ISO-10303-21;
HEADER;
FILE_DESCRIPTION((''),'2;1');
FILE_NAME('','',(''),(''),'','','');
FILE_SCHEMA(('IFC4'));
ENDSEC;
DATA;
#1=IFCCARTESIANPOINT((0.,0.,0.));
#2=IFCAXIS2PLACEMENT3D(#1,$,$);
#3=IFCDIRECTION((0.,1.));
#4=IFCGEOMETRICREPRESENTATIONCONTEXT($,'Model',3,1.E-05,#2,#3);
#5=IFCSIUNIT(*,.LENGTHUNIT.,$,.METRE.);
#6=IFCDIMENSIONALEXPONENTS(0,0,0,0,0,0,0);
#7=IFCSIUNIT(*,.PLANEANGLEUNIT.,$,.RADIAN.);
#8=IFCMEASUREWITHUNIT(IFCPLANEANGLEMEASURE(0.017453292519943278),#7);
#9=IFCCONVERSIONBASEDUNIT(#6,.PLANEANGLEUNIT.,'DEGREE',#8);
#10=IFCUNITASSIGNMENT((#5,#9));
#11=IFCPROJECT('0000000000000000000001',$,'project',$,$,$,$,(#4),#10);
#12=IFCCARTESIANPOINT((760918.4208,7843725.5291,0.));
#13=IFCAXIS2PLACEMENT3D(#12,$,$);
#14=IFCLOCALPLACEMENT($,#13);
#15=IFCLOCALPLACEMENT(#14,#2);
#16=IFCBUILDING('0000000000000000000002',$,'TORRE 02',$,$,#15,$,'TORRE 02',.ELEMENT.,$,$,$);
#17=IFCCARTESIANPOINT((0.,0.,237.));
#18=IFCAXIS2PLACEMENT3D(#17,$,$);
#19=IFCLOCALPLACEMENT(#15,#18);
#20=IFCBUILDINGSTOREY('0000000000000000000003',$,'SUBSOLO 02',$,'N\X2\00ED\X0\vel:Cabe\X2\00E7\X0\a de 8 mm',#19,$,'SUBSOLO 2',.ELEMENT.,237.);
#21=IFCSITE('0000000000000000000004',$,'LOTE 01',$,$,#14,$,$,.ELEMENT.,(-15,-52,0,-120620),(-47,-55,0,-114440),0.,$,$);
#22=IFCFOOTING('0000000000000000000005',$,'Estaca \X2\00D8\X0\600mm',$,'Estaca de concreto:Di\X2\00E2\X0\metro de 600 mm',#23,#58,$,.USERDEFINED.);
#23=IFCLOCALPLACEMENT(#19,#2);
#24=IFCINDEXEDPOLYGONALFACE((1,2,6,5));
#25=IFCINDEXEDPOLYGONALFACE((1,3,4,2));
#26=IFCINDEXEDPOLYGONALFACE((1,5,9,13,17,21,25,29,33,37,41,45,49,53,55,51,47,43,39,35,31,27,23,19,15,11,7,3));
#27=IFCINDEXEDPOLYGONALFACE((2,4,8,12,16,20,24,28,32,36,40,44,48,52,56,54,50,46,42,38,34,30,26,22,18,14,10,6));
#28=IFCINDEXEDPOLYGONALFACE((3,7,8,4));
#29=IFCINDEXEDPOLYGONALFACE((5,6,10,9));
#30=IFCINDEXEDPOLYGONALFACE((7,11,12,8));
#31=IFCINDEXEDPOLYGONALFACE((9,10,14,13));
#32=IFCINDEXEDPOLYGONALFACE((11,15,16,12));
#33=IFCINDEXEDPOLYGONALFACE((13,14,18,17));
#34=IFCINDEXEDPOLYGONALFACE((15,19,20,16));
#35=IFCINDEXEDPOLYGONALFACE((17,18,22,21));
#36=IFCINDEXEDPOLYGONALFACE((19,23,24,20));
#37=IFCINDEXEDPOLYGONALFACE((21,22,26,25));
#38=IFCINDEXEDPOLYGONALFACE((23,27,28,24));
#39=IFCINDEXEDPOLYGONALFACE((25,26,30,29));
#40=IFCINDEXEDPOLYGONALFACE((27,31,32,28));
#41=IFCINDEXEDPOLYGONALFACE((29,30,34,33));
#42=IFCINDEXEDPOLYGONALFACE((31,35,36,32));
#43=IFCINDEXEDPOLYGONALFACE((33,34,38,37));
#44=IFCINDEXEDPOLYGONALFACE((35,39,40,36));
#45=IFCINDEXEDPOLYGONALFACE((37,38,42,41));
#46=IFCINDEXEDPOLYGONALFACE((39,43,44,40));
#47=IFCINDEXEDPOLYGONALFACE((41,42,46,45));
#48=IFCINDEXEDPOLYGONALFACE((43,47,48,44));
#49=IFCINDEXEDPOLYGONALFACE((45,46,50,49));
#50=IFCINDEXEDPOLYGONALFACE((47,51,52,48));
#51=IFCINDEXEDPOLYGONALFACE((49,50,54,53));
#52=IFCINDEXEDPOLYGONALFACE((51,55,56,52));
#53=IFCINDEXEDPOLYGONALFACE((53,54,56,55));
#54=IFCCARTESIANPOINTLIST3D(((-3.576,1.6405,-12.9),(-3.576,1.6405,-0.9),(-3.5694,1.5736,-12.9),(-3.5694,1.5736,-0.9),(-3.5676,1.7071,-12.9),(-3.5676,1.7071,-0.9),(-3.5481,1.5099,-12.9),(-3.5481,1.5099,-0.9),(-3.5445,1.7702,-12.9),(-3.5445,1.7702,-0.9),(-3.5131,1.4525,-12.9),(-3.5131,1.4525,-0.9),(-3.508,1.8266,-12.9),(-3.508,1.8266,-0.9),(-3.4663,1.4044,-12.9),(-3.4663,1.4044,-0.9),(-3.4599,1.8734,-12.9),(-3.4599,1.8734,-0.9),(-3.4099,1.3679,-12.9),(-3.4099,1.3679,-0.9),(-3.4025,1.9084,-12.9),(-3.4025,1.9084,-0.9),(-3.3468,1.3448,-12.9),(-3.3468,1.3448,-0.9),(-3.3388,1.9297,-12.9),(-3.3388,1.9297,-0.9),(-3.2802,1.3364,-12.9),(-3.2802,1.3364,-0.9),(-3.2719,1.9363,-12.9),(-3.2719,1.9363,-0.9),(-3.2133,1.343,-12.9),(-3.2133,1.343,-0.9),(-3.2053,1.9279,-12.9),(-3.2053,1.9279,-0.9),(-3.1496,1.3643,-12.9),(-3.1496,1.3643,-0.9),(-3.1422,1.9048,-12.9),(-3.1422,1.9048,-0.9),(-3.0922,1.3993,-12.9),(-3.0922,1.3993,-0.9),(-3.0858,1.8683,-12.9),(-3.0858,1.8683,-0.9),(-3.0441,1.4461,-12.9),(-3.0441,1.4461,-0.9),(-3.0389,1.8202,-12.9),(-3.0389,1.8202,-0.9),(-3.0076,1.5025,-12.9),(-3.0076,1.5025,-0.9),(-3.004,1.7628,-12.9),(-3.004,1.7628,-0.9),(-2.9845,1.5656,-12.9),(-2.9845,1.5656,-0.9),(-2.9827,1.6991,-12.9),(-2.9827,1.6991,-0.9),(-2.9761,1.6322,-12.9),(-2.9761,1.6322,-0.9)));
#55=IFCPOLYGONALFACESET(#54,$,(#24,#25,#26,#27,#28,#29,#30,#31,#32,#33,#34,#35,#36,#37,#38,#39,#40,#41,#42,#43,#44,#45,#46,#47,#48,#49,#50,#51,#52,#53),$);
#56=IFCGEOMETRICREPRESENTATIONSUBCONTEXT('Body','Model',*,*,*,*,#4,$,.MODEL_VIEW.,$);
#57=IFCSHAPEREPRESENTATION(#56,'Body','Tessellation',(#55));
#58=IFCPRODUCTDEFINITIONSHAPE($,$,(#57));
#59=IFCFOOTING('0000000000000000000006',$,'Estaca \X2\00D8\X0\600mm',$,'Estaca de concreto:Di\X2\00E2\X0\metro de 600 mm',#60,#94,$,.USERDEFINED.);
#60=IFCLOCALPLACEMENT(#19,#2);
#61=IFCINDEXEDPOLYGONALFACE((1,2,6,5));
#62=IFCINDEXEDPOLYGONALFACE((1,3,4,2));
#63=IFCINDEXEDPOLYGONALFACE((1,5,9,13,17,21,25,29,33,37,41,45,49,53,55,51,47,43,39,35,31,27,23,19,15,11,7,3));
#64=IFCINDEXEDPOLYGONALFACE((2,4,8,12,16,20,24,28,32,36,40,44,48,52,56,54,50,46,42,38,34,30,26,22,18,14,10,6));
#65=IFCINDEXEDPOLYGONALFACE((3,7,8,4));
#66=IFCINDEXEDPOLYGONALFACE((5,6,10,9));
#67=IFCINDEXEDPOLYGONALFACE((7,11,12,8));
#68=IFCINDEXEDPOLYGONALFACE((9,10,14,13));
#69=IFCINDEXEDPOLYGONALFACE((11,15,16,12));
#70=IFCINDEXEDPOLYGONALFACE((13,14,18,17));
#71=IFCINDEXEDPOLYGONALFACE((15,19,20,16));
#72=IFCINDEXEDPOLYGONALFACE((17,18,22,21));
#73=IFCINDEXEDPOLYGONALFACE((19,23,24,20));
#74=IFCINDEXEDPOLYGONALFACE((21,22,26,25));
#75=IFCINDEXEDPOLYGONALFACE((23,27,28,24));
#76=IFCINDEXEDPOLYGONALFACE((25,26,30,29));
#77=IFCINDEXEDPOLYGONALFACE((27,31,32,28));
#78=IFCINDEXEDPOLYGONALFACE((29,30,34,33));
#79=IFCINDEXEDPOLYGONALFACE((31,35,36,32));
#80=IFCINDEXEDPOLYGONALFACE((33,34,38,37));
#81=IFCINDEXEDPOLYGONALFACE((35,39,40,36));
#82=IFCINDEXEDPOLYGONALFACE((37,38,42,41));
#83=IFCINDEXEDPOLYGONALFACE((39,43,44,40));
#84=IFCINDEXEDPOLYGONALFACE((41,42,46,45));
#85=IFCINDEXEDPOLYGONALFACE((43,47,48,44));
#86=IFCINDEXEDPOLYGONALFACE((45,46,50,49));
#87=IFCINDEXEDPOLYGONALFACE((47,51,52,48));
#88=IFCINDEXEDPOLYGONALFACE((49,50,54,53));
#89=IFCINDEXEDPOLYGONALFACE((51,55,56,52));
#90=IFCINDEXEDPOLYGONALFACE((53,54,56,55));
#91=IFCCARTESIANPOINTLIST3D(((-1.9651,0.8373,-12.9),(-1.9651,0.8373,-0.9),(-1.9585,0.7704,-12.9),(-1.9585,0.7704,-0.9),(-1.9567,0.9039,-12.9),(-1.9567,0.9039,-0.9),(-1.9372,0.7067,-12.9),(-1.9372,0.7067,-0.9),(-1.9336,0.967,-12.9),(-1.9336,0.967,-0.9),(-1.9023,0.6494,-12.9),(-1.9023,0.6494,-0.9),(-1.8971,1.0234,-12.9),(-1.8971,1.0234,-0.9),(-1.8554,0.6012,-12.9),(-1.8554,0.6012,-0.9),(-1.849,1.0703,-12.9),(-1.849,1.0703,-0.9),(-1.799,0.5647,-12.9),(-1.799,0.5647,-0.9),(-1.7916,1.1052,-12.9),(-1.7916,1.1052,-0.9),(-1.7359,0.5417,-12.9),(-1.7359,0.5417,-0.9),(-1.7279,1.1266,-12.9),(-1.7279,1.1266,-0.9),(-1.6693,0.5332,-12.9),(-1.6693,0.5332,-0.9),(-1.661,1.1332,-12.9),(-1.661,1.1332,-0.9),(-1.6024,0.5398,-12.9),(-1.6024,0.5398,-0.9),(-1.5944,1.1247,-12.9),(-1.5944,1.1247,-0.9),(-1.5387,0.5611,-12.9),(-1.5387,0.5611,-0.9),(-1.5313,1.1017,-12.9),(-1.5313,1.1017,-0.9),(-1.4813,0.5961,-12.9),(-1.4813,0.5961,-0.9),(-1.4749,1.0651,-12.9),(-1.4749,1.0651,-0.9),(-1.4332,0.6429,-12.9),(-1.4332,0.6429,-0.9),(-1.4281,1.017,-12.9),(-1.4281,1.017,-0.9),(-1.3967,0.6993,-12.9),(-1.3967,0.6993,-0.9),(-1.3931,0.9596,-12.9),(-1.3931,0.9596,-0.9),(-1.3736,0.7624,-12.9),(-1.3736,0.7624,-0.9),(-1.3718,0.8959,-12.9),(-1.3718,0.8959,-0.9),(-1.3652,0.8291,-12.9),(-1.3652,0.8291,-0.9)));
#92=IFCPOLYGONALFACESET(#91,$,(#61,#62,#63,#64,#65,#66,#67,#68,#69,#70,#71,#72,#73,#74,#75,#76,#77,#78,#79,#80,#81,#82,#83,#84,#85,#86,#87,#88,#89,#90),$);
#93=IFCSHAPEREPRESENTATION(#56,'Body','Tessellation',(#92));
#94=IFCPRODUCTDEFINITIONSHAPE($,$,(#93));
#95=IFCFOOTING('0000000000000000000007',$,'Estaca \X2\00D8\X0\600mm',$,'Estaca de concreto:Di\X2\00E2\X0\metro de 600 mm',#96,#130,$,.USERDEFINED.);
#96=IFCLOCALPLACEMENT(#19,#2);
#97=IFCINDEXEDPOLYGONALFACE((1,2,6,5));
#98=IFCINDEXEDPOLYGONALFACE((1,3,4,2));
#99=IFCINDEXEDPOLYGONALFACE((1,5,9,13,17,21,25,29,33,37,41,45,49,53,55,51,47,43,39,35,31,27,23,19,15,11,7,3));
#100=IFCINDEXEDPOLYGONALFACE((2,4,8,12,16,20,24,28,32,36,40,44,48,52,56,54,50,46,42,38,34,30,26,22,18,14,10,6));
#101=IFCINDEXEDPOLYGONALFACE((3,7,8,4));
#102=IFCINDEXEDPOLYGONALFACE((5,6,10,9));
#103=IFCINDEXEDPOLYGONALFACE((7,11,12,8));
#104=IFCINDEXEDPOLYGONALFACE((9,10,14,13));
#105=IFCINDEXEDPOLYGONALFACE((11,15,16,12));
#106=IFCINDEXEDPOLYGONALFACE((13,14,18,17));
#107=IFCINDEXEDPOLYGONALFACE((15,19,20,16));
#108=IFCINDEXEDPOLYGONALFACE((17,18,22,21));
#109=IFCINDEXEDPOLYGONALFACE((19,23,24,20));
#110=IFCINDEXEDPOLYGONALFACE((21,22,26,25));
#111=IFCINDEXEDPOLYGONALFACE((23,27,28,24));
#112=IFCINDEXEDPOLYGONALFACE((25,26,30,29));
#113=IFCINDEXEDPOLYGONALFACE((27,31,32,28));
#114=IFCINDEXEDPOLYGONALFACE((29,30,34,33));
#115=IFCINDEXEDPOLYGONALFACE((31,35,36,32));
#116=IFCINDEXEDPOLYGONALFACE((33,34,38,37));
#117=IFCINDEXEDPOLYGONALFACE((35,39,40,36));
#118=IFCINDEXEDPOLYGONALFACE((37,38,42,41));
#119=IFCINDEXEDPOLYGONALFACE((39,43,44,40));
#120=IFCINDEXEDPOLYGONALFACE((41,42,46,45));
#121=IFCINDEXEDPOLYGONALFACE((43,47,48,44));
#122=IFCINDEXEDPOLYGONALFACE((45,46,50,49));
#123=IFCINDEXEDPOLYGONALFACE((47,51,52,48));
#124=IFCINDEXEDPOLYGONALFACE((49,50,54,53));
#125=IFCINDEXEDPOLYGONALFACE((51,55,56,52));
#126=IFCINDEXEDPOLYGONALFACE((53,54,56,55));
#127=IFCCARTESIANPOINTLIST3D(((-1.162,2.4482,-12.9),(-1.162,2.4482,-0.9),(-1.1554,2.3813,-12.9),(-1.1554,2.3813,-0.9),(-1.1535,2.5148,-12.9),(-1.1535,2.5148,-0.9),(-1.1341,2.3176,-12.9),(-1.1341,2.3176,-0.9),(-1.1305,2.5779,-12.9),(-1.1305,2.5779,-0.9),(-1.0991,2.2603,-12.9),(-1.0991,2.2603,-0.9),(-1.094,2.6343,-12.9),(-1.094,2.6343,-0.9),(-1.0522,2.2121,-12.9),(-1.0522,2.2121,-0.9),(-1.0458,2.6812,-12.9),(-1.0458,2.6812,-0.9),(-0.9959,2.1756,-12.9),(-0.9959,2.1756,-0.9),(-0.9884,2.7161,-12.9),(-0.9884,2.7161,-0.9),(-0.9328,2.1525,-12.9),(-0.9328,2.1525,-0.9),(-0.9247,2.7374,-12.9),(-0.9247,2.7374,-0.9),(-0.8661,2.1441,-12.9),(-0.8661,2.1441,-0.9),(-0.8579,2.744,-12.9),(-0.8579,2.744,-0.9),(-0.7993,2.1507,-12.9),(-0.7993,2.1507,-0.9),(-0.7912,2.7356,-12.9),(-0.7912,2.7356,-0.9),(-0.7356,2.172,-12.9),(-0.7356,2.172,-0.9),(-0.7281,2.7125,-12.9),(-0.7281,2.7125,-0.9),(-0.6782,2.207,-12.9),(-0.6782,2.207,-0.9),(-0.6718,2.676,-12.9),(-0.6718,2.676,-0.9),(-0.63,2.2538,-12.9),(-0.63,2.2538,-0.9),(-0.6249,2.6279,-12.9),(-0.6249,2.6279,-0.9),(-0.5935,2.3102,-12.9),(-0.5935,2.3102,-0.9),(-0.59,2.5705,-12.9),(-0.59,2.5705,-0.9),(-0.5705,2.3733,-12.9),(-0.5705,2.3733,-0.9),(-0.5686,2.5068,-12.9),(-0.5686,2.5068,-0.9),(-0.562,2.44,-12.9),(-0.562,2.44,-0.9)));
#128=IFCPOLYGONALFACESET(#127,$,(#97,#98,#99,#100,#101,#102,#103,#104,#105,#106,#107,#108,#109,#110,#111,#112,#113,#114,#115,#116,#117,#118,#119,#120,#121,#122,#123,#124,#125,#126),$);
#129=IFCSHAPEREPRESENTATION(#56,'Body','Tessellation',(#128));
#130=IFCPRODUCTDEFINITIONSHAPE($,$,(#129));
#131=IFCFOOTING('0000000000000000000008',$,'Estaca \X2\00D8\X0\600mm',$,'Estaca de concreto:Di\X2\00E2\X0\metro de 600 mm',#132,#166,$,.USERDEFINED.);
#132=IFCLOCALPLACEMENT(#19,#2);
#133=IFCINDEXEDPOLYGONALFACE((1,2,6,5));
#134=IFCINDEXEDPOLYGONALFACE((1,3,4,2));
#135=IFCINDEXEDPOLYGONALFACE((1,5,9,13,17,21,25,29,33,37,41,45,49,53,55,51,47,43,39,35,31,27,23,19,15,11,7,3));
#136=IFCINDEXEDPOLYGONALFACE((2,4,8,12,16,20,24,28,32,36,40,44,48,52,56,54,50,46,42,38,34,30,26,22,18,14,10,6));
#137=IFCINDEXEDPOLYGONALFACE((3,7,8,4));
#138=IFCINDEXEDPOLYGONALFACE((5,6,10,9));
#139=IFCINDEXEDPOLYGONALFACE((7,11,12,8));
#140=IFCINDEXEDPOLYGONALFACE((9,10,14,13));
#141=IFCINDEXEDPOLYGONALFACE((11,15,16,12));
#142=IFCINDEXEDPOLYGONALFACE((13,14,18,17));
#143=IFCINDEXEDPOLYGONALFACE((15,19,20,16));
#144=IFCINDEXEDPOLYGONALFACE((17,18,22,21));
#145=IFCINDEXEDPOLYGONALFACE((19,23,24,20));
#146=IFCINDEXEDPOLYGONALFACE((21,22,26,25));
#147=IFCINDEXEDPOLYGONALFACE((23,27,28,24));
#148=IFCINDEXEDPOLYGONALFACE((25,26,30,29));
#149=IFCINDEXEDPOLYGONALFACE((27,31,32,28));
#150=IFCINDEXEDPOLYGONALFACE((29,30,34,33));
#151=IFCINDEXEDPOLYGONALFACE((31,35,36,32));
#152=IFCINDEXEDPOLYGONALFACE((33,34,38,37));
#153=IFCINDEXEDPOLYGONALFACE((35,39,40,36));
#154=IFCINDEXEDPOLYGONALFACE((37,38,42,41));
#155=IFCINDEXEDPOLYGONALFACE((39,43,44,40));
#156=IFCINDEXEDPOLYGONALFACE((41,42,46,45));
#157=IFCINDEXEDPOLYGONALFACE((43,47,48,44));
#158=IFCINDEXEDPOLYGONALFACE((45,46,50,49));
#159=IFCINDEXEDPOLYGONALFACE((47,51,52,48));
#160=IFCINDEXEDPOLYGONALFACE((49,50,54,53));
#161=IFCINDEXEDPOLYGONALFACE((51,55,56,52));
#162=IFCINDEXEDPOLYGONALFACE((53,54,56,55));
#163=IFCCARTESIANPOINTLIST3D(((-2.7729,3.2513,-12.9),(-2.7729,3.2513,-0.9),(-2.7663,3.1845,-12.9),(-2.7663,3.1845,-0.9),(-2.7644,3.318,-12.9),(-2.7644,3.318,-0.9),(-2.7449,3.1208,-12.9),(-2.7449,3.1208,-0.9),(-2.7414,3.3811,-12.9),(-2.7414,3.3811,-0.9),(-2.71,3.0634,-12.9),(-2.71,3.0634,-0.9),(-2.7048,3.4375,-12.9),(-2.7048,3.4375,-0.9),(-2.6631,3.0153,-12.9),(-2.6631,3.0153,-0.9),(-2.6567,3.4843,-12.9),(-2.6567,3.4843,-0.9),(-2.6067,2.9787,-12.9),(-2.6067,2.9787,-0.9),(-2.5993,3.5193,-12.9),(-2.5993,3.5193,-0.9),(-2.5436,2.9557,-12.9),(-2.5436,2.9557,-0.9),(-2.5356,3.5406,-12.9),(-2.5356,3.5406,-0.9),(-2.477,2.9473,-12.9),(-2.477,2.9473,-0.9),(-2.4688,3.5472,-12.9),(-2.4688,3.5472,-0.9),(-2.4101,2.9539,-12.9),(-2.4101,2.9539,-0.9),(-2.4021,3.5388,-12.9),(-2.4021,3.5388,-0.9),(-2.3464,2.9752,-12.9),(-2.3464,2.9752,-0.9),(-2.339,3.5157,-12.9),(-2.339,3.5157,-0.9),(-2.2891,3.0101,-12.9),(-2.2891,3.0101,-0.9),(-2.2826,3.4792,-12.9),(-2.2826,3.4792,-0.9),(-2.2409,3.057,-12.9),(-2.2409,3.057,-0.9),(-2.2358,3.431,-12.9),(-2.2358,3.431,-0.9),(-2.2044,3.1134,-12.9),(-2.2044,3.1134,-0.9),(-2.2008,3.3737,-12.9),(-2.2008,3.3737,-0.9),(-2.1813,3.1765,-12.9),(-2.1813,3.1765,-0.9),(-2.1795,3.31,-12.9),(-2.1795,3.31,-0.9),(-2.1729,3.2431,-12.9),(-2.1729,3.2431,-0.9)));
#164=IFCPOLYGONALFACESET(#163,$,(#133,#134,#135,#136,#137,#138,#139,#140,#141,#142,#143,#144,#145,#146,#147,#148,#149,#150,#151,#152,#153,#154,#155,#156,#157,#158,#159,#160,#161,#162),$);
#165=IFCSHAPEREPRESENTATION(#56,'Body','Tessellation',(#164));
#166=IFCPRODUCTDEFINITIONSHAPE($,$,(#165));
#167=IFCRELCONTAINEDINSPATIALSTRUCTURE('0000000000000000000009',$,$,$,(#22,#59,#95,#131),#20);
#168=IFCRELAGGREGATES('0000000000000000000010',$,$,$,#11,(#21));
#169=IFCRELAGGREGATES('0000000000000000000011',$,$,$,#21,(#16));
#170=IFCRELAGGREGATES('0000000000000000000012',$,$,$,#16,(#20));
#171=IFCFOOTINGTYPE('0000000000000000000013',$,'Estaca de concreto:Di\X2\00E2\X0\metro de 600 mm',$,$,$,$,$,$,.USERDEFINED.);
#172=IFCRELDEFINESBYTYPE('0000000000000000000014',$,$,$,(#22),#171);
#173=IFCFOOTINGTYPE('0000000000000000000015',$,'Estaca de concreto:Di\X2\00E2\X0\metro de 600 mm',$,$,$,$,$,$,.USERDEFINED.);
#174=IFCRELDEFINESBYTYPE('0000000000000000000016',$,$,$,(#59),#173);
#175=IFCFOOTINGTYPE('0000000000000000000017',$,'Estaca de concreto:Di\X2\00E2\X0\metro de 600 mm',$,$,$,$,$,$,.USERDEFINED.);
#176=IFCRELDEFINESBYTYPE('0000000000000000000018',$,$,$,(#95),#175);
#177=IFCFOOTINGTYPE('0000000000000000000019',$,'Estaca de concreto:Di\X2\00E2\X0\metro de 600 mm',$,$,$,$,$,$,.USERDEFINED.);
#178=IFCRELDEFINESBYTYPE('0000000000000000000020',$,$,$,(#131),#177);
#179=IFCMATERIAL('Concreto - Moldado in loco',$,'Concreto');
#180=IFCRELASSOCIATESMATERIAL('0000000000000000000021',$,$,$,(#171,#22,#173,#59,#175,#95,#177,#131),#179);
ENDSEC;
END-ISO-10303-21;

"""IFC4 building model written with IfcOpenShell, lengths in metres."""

from ifc_helpers import new_model, entity, si_unit, converted_unit, direction, frame, origin, place, context, subcontext, project, spatial, arc, indexed_curve, outline, extrude, source, transform, mapped, material, type_object, type_shapes, element, save


model = new_model("IFC4")

# Units and contexts
model_context = context("Model", 3, precision=1e-05, world=origin(), true_north=direction((0.0, 1.0)))
body_context = subcontext(model_context, "Body", "Model", "MODEL_VIEW")
ifc_project = project(units=[si_unit("LENGTHUNIT", "METRE"), converted_unit("PLANEANGLEUNIT", "DEGREE", entity("IfcPlaneAngleMeasure", 0.017453292519943278), si_unit("PLANEANGLEUNIT", "RADIAN"), dimensions=[0, 0, 0, 0, 0, 0, 0])], contexts=[model_context])

# Site, building, storey
site_placement = place(None, frame((760918.4208, 7843725.5291, 0.0)))
site = spatial("IfcSite", under=ifc_project, at=site_placement, Name="LOTE 01", CompositionType="ELEMENT", RefLatitude=(-15, -52, 0, -120620), RefLongitude=(-47, -55, 0, -114440), RefElevation=0.0)
building_placement = place(site_placement, origin())
building = spatial("IfcBuilding", under=site, at=building_placement, Name="TORRE 02", LongName="TORRE 02", CompositionType="ELEMENT")
storey_placement = place(building_placement, frame((0.0, 0.0, 237.0)))
storey = spatial("IfcBuildingStorey", under=building, at=storey_placement, Name="SUBSOLO 02", ObjectType="Nível:Cabeça de 8 mm", LongName="SUBSOLO 2", CompositionType="ELEMENT", Elevation=237.0)

# Footings
ifc_material_1 = material(Name="Concreto - Moldado in loco", Category="Concreto")
footing_type_1 = type_object("IfcFootingType", Name="Estaca de concreto:Diâmetro de 600 mm", PredefinedType="USERDEFINED", material=ifc_material_1)
shared_shape_1 = source(origin(), body_context, "Body", "SweptSolid", [
    extrude(outline(indexed_curve([(-0.3, 0.0), (0.0, -0.3), (0.3, 0.0), (0.0, 0.3)], segments=[arc(1, 2, 3), arc(3, 4, 1)], self_intersect=False)), frame((-3.276, 1.6363, -12.0), z_axis=(0.0, 0.0, 1.0), x_axis=(0.894934, -0.446198, 0.0)), (0.0, 0.0, 1.0), 12.0),
])
type_shapes(footing_type_1, [shared_shape_1])
placement = place(building_placement, frame((0.0, 0.0, 237.0)))
footing_1_placement = place(placement, frame((0.0, 0.0, -0.9)))
element("IfcFooting", 1, at=footing_1_placement, inside=storey, type_object=footing_type_1, material=ifc_material_1, Name="Estaca Ø600mm", ObjectType="Estaca de concreto:Diâmetro de 600 mm", PredefinedType="USERDEFINED", context=body_context, shape_type="MappedRepresentation", body=[
    mapped(shared_shape_1, transform((0.0, 0.0, 0.0), scale=1.0)),
])
footing_type_2 = type_object("IfcFootingType", Name="Estaca de concreto:Diâmetro de 600 mm", PredefinedType="USERDEFINED", material=ifc_material_1)
shared_shape_2 = source(origin(), body_context, "Body", "SweptSolid", [
    extrude(outline(indexed_curve([(-0.3, 0.0), (0.0, -0.3), (0.3, 0.0), (0.0, 0.3)], segments=[arc(1, 2, 3), arc(3, 4, 1)], self_intersect=False)), frame((-1.6652, 0.8332, -12.0), z_axis=(0.0, 0.0, 1.0), x_axis=(0.894934, -0.446198, 0.0)), (0.0, 0.0, 1.0), 12.0),
])
type_shapes(footing_type_2, [shared_shape_2])
footing_2_placement = place(placement, frame((0.0, 0.0, -0.9)))
element("IfcFooting", 2, at=footing_2_placement, inside=storey, type_object=footing_type_2, material=ifc_material_1, Name="Estaca Ø600mm", ObjectType="Estaca de concreto:Diâmetro de 600 mm", PredefinedType="USERDEFINED", context=body_context, shape_type="MappedRepresentation", body=[
    mapped(shared_shape_2, transform((0.0, 0.0, 0.0), scale=1.0)),
])
footing_type_3 = type_object("IfcFootingType", Name="Estaca de concreto:Diâmetro de 600 mm", PredefinedType="USERDEFINED", material=ifc_material_1)
shared_shape_3 = source(origin(), body_context, "Body", "SweptSolid", [
    extrude(outline(indexed_curve([(-0.3, 0.0), (0.0, -0.3), (0.3, 0.0), (0.0, 0.3)], segments=[arc(1, 2, 3), arc(3, 4, 1)], self_intersect=False)), frame((-0.862, 2.4441, -12.0), z_axis=(0.0, 0.0, 1.0), x_axis=(0.894934, -0.446198, 0.0)), (0.0, 0.0, 1.0), 12.0),
])
type_shapes(footing_type_3, [shared_shape_3])
footing_3_placement = place(placement, frame((0.0, 0.0, -0.9)))
element("IfcFooting", 3, at=footing_3_placement, inside=storey, type_object=footing_type_3, material=ifc_material_1, Name="Estaca Ø600mm", ObjectType="Estaca de concreto:Diâmetro de 600 mm", PredefinedType="USERDEFINED", context=body_context, shape_type="MappedRepresentation", body=[
    mapped(shared_shape_3, transform((0.0, 0.0, 0.0), scale=1.0)),
])
footing_type_4 = type_object("IfcFootingType", Name="Estaca de concreto:Diâmetro de 600 mm", PredefinedType="USERDEFINED", material=ifc_material_1)
shared_shape_4 = source(origin(), body_context, "Body", "SweptSolid", [
    extrude(outline(indexed_curve([(-0.3, 0.0), (0.0, -0.3), (0.3, 0.0), (0.0, 0.3)], segments=[arc(1, 2, 3), arc(3, 4, 1)], self_intersect=False)), frame((-2.4729, 3.2472, -12.0), z_axis=(0.0, 0.0, 1.0), x_axis=(0.894934, -0.446198, 0.0)), (0.0, 0.0, 1.0), 12.0),
])
type_shapes(footing_type_4, [shared_shape_4])
footing_4_placement = place(placement, frame((0.0, 0.0, -0.9)))
element("IfcFooting", 4, at=footing_4_placement, inside=storey, type_object=footing_type_4, material=ifc_material_1, Name="Estaca Ø600mm", ObjectType="Estaca de concreto:Diâmetro de 600 mm", PredefinedType="USERDEFINED", context=body_context, shape_type="MappedRepresentation", body=[
    mapped(shared_shape_4, transform((0.0, 0.0, 0.0), scale=1.0)),
])

save(model, "model.ifc")
